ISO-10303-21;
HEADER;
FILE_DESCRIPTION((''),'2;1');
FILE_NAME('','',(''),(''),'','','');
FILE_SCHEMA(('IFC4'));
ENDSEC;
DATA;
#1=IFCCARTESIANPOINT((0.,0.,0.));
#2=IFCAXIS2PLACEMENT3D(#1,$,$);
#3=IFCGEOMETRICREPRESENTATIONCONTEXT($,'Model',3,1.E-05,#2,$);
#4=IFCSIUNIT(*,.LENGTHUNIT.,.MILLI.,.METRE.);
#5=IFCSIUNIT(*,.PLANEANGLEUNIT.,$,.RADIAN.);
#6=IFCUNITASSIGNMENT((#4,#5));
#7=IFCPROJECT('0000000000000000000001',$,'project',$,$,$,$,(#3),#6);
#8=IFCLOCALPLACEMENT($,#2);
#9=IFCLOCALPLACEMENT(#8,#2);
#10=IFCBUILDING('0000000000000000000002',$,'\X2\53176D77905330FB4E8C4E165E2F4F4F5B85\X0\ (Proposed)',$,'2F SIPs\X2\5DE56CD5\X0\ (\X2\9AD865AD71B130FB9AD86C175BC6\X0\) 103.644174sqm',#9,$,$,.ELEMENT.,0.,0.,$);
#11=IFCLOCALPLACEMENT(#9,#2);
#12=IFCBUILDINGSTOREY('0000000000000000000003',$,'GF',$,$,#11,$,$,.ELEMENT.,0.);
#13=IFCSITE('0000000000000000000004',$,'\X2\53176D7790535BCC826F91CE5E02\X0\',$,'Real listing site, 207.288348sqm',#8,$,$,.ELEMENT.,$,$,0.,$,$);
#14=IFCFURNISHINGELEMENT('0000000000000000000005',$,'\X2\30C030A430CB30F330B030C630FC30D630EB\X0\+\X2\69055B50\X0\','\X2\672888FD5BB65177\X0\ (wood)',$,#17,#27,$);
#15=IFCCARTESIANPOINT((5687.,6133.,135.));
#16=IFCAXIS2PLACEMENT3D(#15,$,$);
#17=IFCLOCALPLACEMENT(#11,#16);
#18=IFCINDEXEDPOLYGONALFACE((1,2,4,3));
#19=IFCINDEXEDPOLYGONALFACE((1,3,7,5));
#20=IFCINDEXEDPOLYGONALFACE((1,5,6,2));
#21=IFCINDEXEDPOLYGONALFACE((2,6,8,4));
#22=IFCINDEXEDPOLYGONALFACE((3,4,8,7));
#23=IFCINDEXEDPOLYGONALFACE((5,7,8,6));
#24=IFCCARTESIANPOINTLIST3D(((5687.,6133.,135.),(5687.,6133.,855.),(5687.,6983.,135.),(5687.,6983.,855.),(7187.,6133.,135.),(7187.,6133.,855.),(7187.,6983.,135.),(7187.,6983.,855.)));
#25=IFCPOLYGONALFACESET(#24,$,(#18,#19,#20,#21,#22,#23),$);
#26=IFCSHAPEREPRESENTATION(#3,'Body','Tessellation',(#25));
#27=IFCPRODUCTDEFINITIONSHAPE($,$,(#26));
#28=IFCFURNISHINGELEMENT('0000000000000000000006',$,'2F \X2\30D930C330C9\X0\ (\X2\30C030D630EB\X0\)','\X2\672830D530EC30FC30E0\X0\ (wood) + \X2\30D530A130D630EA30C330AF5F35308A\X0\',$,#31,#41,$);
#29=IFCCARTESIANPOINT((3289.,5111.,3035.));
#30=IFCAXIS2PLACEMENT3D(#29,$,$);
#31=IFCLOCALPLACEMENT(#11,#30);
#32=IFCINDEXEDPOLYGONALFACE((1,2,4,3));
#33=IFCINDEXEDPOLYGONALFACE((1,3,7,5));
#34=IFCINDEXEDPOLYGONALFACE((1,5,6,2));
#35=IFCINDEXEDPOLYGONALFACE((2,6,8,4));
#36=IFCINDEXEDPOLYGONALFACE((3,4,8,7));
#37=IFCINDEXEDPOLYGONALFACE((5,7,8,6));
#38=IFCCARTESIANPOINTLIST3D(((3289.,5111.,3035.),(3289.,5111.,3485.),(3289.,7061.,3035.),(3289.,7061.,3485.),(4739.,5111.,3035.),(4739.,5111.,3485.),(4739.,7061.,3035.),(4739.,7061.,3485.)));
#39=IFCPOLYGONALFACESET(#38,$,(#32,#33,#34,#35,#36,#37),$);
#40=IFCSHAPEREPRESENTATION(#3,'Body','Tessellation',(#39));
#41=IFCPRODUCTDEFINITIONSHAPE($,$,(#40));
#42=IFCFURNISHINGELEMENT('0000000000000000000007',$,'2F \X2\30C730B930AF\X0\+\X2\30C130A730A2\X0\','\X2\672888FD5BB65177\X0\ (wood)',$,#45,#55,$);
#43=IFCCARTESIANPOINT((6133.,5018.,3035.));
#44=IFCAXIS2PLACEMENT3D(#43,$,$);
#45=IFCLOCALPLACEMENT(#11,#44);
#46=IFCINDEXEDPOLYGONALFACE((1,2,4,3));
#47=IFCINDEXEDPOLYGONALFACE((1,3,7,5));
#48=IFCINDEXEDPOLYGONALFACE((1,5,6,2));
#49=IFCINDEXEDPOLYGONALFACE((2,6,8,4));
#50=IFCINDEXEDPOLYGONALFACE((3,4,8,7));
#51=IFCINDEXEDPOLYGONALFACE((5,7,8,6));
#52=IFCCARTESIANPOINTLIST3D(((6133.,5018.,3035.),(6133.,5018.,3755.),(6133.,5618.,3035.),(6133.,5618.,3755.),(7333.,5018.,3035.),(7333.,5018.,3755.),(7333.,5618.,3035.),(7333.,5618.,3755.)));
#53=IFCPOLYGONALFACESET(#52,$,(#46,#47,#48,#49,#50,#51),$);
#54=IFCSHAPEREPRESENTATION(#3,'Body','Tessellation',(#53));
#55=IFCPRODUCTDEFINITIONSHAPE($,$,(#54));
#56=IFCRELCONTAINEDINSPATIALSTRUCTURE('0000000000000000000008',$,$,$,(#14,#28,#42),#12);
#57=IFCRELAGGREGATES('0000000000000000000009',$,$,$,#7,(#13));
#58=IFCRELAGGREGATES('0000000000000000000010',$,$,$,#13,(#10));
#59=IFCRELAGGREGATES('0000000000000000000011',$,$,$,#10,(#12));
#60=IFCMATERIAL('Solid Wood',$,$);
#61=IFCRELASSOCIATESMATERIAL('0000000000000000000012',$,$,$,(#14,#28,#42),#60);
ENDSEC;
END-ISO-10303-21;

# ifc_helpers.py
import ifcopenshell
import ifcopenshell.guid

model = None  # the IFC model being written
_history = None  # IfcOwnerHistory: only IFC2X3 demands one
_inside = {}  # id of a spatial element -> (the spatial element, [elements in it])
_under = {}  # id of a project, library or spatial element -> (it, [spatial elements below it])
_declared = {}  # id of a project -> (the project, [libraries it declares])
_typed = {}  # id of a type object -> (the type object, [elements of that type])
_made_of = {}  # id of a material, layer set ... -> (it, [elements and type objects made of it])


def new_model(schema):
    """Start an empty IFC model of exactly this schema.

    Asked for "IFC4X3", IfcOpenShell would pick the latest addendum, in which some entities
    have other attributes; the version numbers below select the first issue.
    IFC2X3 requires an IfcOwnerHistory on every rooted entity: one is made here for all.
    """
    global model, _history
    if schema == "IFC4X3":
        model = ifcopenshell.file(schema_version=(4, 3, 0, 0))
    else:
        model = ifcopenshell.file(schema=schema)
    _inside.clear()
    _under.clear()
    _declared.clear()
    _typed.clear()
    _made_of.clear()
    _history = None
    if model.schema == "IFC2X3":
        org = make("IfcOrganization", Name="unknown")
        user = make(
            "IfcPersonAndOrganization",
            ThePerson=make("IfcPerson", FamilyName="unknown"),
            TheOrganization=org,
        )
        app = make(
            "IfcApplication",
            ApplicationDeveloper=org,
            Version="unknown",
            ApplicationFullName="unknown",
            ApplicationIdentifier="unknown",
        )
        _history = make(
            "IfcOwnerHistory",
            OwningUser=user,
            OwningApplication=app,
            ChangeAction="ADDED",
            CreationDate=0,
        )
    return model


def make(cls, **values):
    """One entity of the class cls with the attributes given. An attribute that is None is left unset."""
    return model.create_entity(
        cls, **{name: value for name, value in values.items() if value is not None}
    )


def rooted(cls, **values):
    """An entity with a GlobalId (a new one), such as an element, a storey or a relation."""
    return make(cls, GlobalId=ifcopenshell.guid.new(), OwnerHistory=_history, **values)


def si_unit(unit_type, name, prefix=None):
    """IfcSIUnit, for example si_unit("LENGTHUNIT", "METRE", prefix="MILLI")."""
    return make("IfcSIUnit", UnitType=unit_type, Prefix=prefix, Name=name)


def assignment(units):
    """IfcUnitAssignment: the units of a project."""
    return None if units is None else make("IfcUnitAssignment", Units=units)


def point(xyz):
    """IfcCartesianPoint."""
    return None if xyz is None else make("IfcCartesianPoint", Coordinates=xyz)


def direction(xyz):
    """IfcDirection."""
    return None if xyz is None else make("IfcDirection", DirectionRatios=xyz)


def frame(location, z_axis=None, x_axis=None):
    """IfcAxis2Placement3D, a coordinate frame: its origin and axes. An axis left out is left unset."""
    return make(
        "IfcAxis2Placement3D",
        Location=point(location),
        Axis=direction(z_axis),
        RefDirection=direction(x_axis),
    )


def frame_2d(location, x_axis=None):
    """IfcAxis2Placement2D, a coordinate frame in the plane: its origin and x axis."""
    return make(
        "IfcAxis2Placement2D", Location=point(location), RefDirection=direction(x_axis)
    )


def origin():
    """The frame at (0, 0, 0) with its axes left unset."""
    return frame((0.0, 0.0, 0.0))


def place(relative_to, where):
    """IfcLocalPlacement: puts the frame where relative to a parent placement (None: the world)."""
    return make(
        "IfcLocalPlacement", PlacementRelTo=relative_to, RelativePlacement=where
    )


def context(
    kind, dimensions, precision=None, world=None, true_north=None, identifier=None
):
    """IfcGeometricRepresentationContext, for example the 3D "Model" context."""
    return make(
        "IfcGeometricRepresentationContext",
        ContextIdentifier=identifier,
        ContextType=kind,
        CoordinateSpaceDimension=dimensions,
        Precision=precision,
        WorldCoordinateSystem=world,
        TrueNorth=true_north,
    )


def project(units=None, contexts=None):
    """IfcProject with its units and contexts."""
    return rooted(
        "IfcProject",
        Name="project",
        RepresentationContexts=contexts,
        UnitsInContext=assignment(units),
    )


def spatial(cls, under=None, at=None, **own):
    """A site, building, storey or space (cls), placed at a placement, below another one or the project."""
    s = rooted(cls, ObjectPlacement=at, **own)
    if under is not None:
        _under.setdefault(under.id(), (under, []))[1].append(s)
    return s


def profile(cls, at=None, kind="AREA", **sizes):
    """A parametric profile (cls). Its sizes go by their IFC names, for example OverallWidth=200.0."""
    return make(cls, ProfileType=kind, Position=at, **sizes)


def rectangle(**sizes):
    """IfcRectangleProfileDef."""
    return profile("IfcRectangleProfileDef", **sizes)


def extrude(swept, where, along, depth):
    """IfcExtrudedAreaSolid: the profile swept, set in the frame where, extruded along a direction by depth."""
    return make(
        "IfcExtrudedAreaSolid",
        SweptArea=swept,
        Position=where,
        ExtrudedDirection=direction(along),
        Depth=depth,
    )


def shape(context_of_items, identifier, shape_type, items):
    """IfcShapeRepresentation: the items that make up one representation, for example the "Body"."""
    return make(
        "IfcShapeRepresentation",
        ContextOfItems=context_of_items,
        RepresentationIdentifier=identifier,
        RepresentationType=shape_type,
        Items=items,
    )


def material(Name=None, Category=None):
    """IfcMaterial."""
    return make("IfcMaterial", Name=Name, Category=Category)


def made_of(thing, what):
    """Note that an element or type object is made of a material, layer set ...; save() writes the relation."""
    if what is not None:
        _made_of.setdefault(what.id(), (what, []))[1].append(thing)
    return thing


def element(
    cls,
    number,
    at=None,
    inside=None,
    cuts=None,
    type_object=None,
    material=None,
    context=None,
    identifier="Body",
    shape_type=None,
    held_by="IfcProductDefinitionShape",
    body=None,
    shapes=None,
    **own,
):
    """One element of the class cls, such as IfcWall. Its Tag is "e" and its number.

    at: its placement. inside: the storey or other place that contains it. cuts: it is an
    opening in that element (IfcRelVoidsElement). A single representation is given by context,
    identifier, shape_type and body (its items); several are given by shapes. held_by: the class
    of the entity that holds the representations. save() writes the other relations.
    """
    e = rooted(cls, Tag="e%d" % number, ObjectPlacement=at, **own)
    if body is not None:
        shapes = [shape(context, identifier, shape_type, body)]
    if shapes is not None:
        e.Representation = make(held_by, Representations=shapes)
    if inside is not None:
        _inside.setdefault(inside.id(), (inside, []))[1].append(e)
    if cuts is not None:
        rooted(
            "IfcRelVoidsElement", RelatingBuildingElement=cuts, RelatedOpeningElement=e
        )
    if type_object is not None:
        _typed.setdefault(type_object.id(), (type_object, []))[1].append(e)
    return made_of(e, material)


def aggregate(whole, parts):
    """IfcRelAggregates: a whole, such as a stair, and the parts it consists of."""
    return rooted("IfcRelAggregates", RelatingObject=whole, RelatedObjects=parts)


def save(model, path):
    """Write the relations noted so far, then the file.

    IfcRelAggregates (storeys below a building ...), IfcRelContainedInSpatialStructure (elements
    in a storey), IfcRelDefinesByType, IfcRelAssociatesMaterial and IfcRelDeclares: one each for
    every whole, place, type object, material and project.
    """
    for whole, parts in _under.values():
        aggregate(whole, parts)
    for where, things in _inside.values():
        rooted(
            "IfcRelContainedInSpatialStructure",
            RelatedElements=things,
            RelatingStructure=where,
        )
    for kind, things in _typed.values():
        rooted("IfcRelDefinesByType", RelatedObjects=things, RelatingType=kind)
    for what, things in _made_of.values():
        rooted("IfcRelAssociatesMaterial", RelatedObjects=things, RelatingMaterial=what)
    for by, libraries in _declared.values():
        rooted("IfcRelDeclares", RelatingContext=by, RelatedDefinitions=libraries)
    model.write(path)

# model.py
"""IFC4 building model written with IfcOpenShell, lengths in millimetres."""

from ifc_helpers import new_model, si_unit, frame, frame_2d, origin, place, context, project, spatial, rectangle, extrude, material, element, save


model = new_model("IFC4")

# Units and contexts
model_context = context("Model", 3, precision=1e-05, world=origin())
ifc_project = project(units=[si_unit("LENGTHUNIT", "METRE", prefix="MILLI"), si_unit("PLANEANGLEUNIT", "RADIAN")], contexts=[model_context])

# Site, building, storey
site_placement = place(None, origin())
site = spatial("IfcSite", under=ifc_project, at=site_placement, Name="北海道富良野市", ObjectType="Real listing site, 207.288348sqm", CompositionType="ELEMENT", RefElevation=0.0)
building_placement = place(site_placement, origin())
building = spatial("IfcBuilding", under=site, at=building_placement, Name="北海道・二世帯住宅 (Proposed)", ObjectType="2F SIPs工法 (高断熱・高気密) 103.644174sqm", CompositionType="ELEMENT", ElevationOfRefHeight=0.0, ElevationOfTerrain=0.0)
storey_placement = place(building_placement, origin())
storey = spatial("IfcBuildingStorey", under=building, at=storey_placement, Name="GF", CompositionType="ELEMENT", Elevation=0.0)

# Shared definitions
ifc_material_1 = material(Name="Solid Wood")

# Furnishing elements
furnishing_1_placement = place(storey_placement, frame((5687.0, 6133.0, 135.0)))
element("IfcFurnishingElement", 1, at=furnishing_1_placement, inside=storey, material=ifc_material_1, Name="ダイニングテーブル+椅子", Description="木製家具 (wood)", context=model_context, shape_type="SweptSolid", body=[
    extrude(rectangle(XDim=1500.0, YDim=850.0, at=frame_2d((750.0, 425.0))), frame((5687.0, 6133.0, 135.0)), (0.0, 0.0, 1.0), 720.0),
])
furnishing_2_placement = place(storey_placement, frame((3289.0, 5111.0, 3035.0)))
element("IfcFurnishingElement", 2, at=furnishing_2_placement, inside=storey, material=ifc_material_1, Name="2F ベッド (ダブル)", Description="木フレーム (wood) + ファブリック張り", context=model_context, shape_type="SweptSolid", body=[
    extrude(rectangle(XDim=1450.0, YDim=1950.0, at=frame_2d((725.0, 975.0))), frame((3289.0, 5111.0, 3035.0)), (0.0, 0.0, 1.0), 450.0),
])
furnishing_3_placement = place(storey_placement, frame((6133.0, 5018.0, 3035.0)))
element("IfcFurnishingElement", 3, at=furnishing_3_placement, inside=storey, material=ifc_material_1, Name="2F デスク+チェア", Description="木製家具 (wood)", context=model_context, shape_type="SweptSolid", body=[
    extrude(rectangle(XDim=1200.0, YDim=600.0, at=frame_2d((600.0, 300.0))), frame((6133.0, 5018.0, 3035.0)), (0.0, 0.0, 1.0), 720.0),
])

save(model, "model.ifc")
